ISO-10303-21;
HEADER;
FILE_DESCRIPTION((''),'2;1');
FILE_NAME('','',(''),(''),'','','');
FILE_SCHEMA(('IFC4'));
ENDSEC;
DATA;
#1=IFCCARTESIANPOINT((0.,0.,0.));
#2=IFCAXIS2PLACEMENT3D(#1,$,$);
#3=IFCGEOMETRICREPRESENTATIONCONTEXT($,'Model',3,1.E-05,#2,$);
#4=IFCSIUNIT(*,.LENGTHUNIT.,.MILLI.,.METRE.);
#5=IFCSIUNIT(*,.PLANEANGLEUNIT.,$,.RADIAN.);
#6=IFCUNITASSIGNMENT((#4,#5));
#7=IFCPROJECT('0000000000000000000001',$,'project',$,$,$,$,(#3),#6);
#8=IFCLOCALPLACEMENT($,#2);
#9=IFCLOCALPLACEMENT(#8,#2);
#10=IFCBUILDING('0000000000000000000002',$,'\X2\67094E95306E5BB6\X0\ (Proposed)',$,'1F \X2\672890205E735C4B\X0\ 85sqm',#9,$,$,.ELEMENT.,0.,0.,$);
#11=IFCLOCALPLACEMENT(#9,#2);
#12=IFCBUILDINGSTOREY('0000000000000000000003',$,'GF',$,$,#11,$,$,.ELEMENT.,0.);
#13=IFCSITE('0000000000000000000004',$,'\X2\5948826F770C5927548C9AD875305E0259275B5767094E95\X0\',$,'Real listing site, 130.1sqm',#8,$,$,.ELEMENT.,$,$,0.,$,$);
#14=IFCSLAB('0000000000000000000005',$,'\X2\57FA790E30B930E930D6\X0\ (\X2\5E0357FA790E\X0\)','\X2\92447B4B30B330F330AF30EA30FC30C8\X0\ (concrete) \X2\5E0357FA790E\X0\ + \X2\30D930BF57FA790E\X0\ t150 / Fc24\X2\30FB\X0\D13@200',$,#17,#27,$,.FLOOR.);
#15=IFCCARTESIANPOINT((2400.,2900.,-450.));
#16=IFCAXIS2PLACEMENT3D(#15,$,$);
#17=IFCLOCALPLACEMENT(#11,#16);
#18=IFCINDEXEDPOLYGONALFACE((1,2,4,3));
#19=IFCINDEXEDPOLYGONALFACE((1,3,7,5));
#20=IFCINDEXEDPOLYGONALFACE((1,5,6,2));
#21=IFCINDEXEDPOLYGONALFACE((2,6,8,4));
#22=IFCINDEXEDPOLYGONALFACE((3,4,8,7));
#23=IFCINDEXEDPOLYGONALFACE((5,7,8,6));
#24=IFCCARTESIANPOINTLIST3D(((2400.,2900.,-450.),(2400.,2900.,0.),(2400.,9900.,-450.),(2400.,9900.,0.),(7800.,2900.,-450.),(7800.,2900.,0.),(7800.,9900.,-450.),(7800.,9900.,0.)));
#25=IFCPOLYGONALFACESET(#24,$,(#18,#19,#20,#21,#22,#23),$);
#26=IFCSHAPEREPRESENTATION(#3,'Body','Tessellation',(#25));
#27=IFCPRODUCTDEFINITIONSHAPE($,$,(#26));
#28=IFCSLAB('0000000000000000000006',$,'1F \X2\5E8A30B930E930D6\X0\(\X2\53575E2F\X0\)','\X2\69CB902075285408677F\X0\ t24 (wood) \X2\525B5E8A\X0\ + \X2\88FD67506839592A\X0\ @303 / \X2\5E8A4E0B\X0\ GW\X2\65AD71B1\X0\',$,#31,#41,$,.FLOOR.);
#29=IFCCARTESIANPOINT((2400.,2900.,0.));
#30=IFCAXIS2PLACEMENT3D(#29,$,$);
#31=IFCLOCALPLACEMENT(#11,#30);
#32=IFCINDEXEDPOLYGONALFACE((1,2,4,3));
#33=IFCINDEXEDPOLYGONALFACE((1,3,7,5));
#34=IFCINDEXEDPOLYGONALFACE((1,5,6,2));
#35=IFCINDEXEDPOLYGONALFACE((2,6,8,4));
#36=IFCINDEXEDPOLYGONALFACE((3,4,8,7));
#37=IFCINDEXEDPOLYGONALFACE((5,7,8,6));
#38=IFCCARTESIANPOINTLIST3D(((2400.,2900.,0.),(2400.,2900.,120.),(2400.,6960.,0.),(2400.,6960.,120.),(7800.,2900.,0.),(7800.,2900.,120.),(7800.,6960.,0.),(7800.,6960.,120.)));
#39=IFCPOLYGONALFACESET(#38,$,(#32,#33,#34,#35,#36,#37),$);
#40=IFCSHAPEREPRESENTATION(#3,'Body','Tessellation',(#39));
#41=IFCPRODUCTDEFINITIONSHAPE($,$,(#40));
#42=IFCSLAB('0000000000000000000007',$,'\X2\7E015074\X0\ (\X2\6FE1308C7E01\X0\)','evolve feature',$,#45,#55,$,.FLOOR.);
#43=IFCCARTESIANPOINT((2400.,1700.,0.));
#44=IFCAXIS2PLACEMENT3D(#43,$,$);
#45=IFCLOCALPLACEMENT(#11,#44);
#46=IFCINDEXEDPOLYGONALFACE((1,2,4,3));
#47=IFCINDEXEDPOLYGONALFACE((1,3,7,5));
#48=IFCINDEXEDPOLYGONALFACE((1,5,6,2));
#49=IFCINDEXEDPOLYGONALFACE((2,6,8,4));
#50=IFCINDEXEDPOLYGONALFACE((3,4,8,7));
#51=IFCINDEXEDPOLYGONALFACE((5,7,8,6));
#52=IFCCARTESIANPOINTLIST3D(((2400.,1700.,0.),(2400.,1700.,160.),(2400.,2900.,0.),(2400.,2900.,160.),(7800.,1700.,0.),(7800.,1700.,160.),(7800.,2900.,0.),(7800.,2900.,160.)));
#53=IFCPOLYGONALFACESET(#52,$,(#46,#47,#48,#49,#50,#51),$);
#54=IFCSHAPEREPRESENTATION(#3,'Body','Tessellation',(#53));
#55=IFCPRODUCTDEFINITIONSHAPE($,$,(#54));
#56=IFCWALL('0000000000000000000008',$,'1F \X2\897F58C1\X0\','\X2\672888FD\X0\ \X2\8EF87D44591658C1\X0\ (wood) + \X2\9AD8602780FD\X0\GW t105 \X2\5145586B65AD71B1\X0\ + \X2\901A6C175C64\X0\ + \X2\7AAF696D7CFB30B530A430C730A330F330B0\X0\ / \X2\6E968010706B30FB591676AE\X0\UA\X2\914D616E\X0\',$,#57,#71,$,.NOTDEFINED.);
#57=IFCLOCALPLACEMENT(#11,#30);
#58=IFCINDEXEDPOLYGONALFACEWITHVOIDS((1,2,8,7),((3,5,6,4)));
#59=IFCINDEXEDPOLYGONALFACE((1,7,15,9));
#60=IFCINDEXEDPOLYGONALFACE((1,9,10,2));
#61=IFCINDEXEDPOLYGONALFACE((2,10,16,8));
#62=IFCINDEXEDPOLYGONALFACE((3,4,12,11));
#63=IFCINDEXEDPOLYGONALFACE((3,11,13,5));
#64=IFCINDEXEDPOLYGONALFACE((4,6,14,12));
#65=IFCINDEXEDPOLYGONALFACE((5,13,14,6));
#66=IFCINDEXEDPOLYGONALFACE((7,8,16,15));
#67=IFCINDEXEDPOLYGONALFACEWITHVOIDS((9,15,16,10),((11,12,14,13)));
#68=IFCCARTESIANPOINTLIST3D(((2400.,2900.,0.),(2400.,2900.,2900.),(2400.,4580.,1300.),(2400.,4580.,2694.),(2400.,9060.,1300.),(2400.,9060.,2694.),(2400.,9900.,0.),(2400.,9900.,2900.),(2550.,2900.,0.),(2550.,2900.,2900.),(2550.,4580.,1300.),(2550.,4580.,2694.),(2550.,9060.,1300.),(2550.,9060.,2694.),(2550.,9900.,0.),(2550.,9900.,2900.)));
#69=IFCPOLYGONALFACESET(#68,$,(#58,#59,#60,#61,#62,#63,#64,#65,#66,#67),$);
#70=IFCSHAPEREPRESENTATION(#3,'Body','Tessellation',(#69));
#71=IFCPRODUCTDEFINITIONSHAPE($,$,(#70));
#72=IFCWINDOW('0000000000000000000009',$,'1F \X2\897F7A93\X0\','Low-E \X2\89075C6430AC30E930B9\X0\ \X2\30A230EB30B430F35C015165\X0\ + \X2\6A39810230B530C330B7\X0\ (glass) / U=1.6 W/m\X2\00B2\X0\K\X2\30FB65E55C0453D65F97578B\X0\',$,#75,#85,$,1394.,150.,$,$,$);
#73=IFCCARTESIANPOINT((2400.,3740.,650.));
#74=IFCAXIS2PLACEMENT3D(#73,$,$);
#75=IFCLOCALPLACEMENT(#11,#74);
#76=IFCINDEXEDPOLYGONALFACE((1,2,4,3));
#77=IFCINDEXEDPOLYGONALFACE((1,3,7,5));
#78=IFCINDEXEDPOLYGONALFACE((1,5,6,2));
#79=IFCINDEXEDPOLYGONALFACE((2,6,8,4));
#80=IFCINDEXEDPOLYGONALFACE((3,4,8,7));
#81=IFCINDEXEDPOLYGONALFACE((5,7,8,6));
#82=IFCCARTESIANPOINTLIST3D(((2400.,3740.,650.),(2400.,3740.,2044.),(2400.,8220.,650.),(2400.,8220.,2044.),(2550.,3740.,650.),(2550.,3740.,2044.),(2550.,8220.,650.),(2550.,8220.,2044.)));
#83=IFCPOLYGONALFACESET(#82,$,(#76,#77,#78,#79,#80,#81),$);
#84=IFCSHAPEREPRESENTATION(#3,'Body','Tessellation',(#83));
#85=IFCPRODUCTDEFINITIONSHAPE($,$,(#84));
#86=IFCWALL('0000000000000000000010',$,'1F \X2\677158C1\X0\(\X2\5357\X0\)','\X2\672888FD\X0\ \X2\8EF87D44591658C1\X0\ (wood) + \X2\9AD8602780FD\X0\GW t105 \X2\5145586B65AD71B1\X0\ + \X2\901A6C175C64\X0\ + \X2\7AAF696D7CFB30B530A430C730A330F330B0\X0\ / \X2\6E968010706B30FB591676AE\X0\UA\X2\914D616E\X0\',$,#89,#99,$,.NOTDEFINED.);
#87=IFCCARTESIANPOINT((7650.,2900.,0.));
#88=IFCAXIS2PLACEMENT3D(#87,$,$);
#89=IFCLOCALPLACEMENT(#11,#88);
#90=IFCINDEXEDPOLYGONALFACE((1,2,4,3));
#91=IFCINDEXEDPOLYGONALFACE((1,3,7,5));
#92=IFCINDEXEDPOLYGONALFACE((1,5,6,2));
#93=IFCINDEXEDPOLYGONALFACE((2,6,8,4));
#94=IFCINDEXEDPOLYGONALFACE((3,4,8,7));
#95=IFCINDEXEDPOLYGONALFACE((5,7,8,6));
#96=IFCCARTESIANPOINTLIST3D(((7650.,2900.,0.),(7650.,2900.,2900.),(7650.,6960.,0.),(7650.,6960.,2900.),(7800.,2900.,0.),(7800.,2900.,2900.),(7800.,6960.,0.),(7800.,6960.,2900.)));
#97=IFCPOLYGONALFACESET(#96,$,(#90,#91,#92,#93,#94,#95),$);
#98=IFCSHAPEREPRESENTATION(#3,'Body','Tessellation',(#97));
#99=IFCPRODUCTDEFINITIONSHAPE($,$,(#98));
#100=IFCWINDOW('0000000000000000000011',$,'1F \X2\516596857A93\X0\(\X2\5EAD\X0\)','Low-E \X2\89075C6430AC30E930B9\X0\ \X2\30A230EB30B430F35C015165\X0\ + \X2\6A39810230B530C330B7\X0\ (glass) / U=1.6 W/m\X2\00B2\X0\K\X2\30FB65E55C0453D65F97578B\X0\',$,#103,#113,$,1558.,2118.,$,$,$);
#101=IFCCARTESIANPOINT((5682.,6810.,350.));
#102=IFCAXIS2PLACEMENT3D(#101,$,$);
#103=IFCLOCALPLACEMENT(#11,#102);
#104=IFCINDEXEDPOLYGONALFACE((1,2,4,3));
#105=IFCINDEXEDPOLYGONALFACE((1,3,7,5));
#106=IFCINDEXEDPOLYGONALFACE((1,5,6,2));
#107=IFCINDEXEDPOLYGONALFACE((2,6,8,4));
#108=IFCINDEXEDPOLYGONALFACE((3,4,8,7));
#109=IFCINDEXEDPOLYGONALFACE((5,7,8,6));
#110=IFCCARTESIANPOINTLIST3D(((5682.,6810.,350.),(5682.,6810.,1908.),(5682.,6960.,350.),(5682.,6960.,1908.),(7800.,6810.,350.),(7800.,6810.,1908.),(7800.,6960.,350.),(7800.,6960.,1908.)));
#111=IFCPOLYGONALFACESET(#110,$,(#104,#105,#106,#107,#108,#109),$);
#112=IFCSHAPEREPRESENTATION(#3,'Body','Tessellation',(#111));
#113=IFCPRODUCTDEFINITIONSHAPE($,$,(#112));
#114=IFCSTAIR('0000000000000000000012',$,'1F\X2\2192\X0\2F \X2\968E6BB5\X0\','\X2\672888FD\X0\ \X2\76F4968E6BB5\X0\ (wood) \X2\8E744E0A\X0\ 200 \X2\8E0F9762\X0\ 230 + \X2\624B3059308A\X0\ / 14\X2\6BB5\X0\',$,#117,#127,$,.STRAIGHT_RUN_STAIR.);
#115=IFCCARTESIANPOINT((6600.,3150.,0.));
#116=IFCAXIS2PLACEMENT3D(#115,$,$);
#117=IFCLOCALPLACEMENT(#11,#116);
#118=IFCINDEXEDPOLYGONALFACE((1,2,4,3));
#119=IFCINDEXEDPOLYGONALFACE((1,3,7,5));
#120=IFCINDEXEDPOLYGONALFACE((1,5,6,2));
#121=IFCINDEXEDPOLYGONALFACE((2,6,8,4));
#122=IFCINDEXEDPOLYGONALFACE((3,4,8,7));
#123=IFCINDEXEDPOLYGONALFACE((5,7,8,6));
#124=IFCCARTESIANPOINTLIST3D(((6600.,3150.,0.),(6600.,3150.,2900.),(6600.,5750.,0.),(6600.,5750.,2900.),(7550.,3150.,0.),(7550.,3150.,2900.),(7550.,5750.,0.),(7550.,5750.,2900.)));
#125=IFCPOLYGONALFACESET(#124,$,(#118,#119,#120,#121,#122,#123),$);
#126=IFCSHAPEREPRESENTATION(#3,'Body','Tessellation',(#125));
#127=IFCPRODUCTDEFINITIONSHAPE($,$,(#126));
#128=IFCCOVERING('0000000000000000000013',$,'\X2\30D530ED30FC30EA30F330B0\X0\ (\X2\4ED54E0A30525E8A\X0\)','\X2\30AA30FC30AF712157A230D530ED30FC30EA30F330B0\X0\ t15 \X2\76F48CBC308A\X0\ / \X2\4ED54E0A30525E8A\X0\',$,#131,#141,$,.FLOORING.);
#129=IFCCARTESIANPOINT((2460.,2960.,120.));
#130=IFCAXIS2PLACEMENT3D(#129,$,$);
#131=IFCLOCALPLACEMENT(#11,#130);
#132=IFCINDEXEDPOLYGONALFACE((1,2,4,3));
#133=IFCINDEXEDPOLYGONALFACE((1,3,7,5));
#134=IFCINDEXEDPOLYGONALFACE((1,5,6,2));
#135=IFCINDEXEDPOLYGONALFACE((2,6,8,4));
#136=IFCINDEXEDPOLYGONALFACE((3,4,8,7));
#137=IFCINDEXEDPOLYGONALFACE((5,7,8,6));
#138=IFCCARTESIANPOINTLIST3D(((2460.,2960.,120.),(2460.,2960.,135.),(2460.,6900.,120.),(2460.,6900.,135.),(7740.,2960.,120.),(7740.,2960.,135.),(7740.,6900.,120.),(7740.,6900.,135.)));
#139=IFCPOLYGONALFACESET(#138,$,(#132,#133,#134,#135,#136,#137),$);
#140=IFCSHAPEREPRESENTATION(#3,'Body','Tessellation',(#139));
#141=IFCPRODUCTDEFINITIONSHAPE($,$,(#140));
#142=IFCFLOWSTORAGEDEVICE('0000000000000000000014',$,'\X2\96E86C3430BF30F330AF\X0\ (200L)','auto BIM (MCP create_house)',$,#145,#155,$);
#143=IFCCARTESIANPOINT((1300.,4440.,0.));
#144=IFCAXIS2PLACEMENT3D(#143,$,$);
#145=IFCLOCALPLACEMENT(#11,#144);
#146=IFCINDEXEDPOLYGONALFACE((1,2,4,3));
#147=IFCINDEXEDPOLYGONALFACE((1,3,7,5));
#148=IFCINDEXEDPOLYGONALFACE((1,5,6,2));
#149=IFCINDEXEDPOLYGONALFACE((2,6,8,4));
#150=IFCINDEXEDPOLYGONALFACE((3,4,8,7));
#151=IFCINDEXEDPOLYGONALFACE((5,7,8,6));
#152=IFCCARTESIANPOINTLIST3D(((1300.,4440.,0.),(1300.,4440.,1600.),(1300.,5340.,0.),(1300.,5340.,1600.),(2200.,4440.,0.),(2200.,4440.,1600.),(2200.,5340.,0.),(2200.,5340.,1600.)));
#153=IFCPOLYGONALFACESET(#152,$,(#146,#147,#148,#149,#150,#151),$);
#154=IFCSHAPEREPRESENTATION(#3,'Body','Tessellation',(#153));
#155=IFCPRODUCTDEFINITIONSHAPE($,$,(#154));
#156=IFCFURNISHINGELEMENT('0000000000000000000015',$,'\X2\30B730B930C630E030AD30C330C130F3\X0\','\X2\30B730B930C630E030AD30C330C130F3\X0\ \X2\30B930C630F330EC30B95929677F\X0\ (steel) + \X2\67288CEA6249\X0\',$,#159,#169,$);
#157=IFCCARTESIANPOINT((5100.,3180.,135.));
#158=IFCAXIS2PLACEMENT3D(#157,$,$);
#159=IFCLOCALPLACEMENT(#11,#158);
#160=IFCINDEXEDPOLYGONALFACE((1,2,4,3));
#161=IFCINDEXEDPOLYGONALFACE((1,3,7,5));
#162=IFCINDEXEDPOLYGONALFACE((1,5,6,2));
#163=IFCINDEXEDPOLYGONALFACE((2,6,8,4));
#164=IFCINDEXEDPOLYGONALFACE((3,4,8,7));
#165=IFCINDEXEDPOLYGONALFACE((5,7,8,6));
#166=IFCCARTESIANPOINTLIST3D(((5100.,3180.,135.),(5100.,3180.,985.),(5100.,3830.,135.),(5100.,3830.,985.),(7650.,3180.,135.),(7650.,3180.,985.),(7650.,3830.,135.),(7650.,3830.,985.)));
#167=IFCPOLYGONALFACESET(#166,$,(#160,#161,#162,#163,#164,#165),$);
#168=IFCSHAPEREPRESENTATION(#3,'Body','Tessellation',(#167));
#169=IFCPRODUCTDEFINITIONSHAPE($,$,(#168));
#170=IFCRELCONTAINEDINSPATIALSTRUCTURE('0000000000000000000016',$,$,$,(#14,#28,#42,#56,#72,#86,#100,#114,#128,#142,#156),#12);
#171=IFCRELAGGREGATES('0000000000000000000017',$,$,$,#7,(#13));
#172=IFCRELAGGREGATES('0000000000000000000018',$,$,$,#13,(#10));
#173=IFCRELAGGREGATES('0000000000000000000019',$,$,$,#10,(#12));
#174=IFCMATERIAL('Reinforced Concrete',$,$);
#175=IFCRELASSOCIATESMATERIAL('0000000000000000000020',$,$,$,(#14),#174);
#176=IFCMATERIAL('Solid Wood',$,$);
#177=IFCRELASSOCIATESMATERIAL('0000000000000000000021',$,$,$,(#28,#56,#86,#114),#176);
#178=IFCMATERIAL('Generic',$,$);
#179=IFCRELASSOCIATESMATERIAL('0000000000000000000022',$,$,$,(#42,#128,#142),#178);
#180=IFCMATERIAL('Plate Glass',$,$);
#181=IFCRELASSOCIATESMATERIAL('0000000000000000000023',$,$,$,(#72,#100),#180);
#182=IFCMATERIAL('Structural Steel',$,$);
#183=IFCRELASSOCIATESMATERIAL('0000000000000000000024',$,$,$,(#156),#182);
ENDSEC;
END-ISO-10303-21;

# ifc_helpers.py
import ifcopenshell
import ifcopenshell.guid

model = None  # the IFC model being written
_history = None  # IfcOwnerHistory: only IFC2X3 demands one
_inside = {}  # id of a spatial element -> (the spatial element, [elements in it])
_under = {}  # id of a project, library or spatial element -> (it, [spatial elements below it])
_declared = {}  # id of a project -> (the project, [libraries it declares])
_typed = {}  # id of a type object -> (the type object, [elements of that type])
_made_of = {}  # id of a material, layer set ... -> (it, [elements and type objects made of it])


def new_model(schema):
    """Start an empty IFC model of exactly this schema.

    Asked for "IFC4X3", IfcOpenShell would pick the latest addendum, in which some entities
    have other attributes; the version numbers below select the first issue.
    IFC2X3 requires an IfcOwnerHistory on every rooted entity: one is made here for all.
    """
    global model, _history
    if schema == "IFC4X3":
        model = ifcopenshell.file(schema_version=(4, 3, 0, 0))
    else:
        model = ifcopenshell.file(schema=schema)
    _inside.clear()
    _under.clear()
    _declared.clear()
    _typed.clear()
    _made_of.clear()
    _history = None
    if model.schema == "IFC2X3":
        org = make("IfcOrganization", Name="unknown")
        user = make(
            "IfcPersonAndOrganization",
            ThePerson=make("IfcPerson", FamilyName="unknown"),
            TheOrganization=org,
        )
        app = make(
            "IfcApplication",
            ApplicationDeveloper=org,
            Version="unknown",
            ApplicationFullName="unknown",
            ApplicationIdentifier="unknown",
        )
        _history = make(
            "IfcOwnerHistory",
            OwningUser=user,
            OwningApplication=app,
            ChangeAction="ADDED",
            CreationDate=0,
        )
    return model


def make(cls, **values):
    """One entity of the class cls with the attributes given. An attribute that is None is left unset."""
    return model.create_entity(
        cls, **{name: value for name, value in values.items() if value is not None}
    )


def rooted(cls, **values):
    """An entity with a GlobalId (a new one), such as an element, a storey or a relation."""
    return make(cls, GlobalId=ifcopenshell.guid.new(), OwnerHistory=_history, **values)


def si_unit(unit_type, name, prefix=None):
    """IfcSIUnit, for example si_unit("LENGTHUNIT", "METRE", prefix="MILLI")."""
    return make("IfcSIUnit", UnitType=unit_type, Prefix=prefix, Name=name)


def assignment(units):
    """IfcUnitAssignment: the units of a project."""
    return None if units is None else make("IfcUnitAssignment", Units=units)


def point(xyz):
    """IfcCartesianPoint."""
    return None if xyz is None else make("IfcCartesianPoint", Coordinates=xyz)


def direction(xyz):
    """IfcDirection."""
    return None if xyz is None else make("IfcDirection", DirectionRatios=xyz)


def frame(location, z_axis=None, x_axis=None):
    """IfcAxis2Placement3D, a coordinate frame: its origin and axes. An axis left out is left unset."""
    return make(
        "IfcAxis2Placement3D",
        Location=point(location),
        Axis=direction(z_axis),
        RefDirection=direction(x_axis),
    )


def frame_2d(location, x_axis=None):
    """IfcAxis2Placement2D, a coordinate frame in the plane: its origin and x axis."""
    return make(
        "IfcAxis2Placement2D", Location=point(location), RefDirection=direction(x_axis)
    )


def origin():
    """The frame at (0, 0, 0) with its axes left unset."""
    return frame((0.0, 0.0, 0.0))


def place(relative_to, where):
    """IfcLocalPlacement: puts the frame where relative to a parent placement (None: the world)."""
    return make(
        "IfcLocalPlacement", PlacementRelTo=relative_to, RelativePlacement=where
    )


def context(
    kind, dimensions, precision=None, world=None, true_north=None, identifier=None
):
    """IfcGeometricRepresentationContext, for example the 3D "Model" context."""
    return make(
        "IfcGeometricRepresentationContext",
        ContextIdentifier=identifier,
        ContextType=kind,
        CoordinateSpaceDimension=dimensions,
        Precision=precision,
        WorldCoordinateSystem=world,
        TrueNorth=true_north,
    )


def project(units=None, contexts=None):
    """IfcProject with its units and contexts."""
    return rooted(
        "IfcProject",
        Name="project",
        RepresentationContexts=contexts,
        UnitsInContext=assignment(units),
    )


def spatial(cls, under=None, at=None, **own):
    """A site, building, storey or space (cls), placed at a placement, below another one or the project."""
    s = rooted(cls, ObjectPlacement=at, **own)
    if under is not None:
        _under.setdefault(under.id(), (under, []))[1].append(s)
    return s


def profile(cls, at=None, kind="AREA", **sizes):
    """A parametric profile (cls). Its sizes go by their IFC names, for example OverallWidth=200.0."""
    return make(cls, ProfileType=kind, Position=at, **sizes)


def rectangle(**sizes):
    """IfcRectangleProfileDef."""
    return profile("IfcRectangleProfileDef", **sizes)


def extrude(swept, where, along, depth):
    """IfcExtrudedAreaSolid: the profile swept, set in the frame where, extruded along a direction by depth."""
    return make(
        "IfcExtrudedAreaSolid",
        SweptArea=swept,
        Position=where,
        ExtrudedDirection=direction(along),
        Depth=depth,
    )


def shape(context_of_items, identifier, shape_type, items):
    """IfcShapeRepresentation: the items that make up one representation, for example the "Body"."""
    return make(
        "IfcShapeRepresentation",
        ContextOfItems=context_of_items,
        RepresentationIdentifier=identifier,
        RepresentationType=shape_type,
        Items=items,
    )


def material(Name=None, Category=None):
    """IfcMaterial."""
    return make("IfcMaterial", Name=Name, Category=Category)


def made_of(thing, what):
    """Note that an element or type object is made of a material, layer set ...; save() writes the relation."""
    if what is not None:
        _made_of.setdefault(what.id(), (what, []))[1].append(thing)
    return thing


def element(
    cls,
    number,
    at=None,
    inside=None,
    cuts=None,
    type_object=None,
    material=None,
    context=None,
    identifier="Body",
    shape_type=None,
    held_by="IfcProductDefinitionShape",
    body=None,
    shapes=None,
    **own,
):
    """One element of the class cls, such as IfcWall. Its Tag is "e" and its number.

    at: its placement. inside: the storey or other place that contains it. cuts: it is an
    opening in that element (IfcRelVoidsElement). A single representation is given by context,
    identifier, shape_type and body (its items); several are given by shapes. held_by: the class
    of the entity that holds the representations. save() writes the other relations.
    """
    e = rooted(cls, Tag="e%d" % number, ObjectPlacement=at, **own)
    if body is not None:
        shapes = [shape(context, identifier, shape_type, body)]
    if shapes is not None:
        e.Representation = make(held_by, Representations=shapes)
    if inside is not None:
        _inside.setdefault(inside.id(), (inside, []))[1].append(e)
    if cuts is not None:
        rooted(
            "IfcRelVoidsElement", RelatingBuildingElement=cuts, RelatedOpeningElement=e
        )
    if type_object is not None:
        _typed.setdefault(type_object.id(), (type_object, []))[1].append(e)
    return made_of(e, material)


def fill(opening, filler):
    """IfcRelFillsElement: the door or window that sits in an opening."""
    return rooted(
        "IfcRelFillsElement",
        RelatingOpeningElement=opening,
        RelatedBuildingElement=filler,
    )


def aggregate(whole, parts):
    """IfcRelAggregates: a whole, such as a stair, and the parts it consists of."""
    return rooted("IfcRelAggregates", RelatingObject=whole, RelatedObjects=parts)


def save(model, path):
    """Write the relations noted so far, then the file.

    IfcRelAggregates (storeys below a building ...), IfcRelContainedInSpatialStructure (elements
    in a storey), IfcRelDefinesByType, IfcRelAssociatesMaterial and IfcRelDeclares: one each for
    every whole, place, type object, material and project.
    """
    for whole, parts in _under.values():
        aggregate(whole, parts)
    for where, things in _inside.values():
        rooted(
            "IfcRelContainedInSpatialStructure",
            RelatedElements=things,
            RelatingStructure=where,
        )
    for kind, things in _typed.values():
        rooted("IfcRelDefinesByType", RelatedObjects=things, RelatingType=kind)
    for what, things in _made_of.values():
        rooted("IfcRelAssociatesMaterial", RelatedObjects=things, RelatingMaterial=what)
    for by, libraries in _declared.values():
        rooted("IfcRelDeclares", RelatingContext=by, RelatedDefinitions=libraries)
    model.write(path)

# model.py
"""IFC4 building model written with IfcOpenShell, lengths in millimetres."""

from ifc_helpers import new_model, si_unit, frame, frame_2d, origin, place, context, project, spatial, rectangle, extrude, material, element, fill, save


model = new_model("IFC4")

# Units and contexts
model_context = context("Model", 3, precision=1e-05, world=origin())
ifc_project = project(units=[si_unit("LENGTHUNIT", "METRE", prefix="MILLI"), si_unit("PLANEANGLEUNIT", "RADIAN")], contexts=[model_context])

# Site, building, storey
site_placement = place(None, origin())
site = spatial("IfcSite", under=ifc_project, at=site_placement, Name="奈良県大和高田市大字有井", ObjectType="Real listing site, 130.1sqm", CompositionType="ELEMENT", RefElevation=0.0)
building_placement = place(site_placement, origin())
building = spatial("IfcBuilding", under=site, at=building_placement, Name="有井の家 (Proposed)", ObjectType="1F 木造平屋 85sqm", CompositionType="ELEMENT", ElevationOfRefHeight=0.0, ElevationOfTerrain=0.0)
storey_placement = place(building_placement, origin())
storey = spatial("IfcBuildingStorey", under=building, at=storey_placement, Name="GF", CompositionType="ELEMENT", Elevation=0.0)

# Slabs
ifc_material_1 = material(Name="Reinforced Concrete")
slab_1_placement = place(storey_placement, frame((2400.0, 2900.0, -450.0)))
element("IfcSlab", 1, at=slab_1_placement, inside=storey, material=ifc_material_1, Name="基礎スラブ (布基礎)", Description="鉄筋コンクリート (concrete) 布基礎 + ベタ基礎 t150 / Fc24・D13@200", PredefinedType="FLOOR", context=model_context, shape_type="SweptSolid", body=[
    extrude(rectangle(XDim=5400.0, YDim=7000.0, at=frame_2d((2700.0, 3500.0))), frame((2400.0, 2900.0, -450.0)), (0.0, 0.0, 1.0), 450.0),
])
ifc_material_2 = material(Name="Solid Wood")
slab_2_placement = place(storey_placement, frame((2400.0, 2900.0, 0.0)))
element("IfcSlab", 2, at=slab_2_placement, inside=storey, material=ifc_material_2, Name="1F 床スラブ(南帯)", Description="構造用合板 t24 (wood) 剛床 + 製材根太 @303 / 床下 GW断熱", PredefinedType="FLOOR", context=model_context, shape_type="SweptSolid", body=[
    extrude(rectangle(XDim=5400.0, YDim=4060.0, at=frame_2d((2700.0, 2030.0))), frame((2400.0, 2900.0, 0.0)), (0.0, 0.0, 1.0), 120.0),
])
ifc_material_3 = material(Name="Generic")
slab_3_placement = place(storey_placement, frame((2400.0, 1700.0, 0.0)))
element("IfcSlab", 3, at=slab_3_placement, inside=storey, material=ifc_material_3, Name="縁側 (濡れ縁)", Description="evolve feature", PredefinedType="FLOOR", context=model_context, shape_type="SweptSolid", body=[
    extrude(rectangle(XDim=5400.0, YDim=1200.0, at=frame_2d((2700.0, 600.0))), frame((2400.0, 1700.0, 0.0)), (0.0, 0.0, 1.0), 160.0),
])

# Shared definitions
ifc_material_4 = material(Name="Plate Glass")

# Walls, openings, windows
wall_1_placement = place(storey_placement, frame((2400.0, 2900.0, 0.0)))
wall_1 = element("IfcWall", 4, at=wall_1_placement, inside=storey, material=ifc_material_2, Name="1F 西壁", Description="木製 軸組外壁 (wood) + 高性能GW t105 充填断熱 + 通気層 + 窯業系サイディング / 準耐火・外皮UA配慮", PredefinedType="NOTDEFINED", context=model_context, shape_type="SweptSolid", body=[
    extrude(rectangle(XDim=150.0, YDim=7000.0, at=frame_2d((75.0, 3500.0))), frame((2400.0, 2900.0, 0.0)), (0.0, 0.0, 1.0), 2900.0),
])
opening_1_placement = place(storey_placement, frame((2400.0, 3740.0, 650.0)))
opening_1 = element("IfcOpeningElement", 5, at=opening_1_placement, cuts=wall_1, PredefinedType="NOTDEFINED", context=model_context, shape_type="SweptSolid", body=[
    extrude(rectangle(XDim=150.0, YDim=4480.0, at=frame_2d((75.0, 2240.0))), frame((2400.0, 3740.0, 650.0)), (0.0, 0.0, 1.0), 1394.0),
])
window_1_placement = place(storey_placement, frame((2400.0, 3740.0, 650.0)))
window_1 = element("IfcWindow", 6, at=window_1_placement, inside=storey, material=ifc_material_4, Name="1F 西窓", Description="Low-E 複層ガラス アルゴン封入 + 樹脂サッシ (glass) / U=1.6 W/m²K・日射取得型", OverallHeight=1394.0, OverallWidth=150.0, context=model_context, shape_type="SweptSolid", body=[
    extrude(rectangle(XDim=150.0, YDim=4480.0, at=frame_2d((75.0, 2240.0))), frame((2400.0, 3740.0, 650.0)), (0.0, 0.0, 1.0), 1394.0),
])
fill(opening_1, window_1)
wall_2_placement = place(storey_placement, frame((7650.0, 2900.0, 0.0)))
wall_2 = element("IfcWall", 7, at=wall_2_placement, inside=storey, material=ifc_material_2, Name="1F 東壁(南)", Description="木製 軸組外壁 (wood) + 高性能GW t105 充填断熱 + 通気層 + 窯業系サイディング / 準耐火・外皮UA配慮", PredefinedType="NOTDEFINED", context=model_context, shape_type="SweptSolid", body=[
    extrude(rectangle(XDim=150.0, YDim=4060.0, at=frame_2d((75.0, 2030.0))), frame((7650.0, 2900.0, 0.0)), (0.0, 0.0, 1.0), 2900.0),
])
opening_2_placement = place(storey_placement, frame((5682.0, 6810.0, 350.0)))
opening_2 = element("IfcOpeningElement", 8, at=opening_2_placement, cuts=wall_2, PredefinedType="NOTDEFINED", context=model_context, shape_type="SweptSolid", body=[
    extrude(rectangle(XDim=2118.0, YDim=150.0, at=frame_2d((1059.0, 75.0))), frame((5682.0, 6810.0, 350.0)), (0.0, 0.0, 1.0), 1558.0),
])
window_2_placement = place(storey_placement, frame((5682.0, 6810.0, 350.0)))
window_2 = element("IfcWindow", 9, at=window_2_placement, inside=storey, material=ifc_material_4, Name="1F 入隅窓(庭)", Description="Low-E 複層ガラス アルゴン封入 + 樹脂サッシ (glass) / U=1.6 W/m²K・日射取得型", OverallHeight=1558.0, OverallWidth=2118.0, context=model_context, shape_type="SweptSolid", body=[
    extrude(rectangle(XDim=2118.0, YDim=150.0, at=frame_2d((1059.0, 75.0))), frame((5682.0, 6810.0, 350.0)), (0.0, 0.0, 1.0), 1558.0),
])
fill(opening_2, window_2)

# Stair
stair_placement = place(storey_placement, frame((6600.0, 3150.0, 0.0)))
element("IfcStair", 10, at=stair_placement, inside=storey, material=ifc_material_2, Name="1F→2F 階段", Description="木製 直階段 (wood) 蹴上 200 踏面 230 + 手すり / 14段", PredefinedType="STRAIGHT_RUN_STAIR", context=model_context, shape_type="SweptSolid", body=[
    extrude(rectangle(XDim=950.0, YDim=2600.0, at=frame_2d((475.0, 1300.0))), frame((6600.0, 3150.0, 0.0)), (0.0, 0.0, 1.0), 2900.0),
])

# Covering
covering_placement = place(storey_placement, frame((2460.0, 2960.0, 120.0)))
element("IfcCovering", 11, at=covering_placement, inside=storey, material=ifc_material_3, Name="フローリング (仕上げ床)", Description="オーク無垢フローリング t15 直貼り / 仕上げ床", PredefinedType="FLOORING", context=model_context, shape_type="SweptSolid", body=[
    extrude(rectangle(XDim=5280.0, YDim=3940.0, at=frame_2d((2640.0, 1970.0))), frame((2460.0, 2960.0, 120.0)), (0.0, 0.0, 1.0), 15.0),
])

# Flow storage device
flow_storage_device_placement = place(storey_placement, frame((1300.0, 4440.0, 0.0)))
element("IfcFlowStorageDevice", 12, at=flow_storage_device_placement, inside=storey, material=ifc_material_3, Name="雨水タンク (200L)", Description="auto BIM (MCP create_house)", context=model_context, shape_type="SweptSolid", body=[
    extrude(rectangle(XDim=900.0, YDim=900.0, at=frame_2d((450.0, 450.0))), frame((1300.0, 4440.0, 0.0)), (0.0, 0.0, 1.0), 1600.0),
])

# Furnishing element
ifc_material_5 = material(Name="Structural Steel")
furnishing_placement = place(storey_placement, frame((5100.0, 3180.0, 135.0)))
element("IfcFurnishingElement", 13, at=furnishing_placement, inside=storey, material=ifc_material_5, Name="システムキッチン", Description="システムキッチン ステンレス天板 (steel) + 木質扉", context=model_context, shape_type="SweptSolid", body=[
    extrude(rectangle(XDim=2550.0, YDim=650.0, at=frame_2d((1275.0, 325.0))), frame((5100.0, 3180.0, 135.0)), (0.0, 0.0, 1.0), 850.0),
])

save(model, "model.ifc")
